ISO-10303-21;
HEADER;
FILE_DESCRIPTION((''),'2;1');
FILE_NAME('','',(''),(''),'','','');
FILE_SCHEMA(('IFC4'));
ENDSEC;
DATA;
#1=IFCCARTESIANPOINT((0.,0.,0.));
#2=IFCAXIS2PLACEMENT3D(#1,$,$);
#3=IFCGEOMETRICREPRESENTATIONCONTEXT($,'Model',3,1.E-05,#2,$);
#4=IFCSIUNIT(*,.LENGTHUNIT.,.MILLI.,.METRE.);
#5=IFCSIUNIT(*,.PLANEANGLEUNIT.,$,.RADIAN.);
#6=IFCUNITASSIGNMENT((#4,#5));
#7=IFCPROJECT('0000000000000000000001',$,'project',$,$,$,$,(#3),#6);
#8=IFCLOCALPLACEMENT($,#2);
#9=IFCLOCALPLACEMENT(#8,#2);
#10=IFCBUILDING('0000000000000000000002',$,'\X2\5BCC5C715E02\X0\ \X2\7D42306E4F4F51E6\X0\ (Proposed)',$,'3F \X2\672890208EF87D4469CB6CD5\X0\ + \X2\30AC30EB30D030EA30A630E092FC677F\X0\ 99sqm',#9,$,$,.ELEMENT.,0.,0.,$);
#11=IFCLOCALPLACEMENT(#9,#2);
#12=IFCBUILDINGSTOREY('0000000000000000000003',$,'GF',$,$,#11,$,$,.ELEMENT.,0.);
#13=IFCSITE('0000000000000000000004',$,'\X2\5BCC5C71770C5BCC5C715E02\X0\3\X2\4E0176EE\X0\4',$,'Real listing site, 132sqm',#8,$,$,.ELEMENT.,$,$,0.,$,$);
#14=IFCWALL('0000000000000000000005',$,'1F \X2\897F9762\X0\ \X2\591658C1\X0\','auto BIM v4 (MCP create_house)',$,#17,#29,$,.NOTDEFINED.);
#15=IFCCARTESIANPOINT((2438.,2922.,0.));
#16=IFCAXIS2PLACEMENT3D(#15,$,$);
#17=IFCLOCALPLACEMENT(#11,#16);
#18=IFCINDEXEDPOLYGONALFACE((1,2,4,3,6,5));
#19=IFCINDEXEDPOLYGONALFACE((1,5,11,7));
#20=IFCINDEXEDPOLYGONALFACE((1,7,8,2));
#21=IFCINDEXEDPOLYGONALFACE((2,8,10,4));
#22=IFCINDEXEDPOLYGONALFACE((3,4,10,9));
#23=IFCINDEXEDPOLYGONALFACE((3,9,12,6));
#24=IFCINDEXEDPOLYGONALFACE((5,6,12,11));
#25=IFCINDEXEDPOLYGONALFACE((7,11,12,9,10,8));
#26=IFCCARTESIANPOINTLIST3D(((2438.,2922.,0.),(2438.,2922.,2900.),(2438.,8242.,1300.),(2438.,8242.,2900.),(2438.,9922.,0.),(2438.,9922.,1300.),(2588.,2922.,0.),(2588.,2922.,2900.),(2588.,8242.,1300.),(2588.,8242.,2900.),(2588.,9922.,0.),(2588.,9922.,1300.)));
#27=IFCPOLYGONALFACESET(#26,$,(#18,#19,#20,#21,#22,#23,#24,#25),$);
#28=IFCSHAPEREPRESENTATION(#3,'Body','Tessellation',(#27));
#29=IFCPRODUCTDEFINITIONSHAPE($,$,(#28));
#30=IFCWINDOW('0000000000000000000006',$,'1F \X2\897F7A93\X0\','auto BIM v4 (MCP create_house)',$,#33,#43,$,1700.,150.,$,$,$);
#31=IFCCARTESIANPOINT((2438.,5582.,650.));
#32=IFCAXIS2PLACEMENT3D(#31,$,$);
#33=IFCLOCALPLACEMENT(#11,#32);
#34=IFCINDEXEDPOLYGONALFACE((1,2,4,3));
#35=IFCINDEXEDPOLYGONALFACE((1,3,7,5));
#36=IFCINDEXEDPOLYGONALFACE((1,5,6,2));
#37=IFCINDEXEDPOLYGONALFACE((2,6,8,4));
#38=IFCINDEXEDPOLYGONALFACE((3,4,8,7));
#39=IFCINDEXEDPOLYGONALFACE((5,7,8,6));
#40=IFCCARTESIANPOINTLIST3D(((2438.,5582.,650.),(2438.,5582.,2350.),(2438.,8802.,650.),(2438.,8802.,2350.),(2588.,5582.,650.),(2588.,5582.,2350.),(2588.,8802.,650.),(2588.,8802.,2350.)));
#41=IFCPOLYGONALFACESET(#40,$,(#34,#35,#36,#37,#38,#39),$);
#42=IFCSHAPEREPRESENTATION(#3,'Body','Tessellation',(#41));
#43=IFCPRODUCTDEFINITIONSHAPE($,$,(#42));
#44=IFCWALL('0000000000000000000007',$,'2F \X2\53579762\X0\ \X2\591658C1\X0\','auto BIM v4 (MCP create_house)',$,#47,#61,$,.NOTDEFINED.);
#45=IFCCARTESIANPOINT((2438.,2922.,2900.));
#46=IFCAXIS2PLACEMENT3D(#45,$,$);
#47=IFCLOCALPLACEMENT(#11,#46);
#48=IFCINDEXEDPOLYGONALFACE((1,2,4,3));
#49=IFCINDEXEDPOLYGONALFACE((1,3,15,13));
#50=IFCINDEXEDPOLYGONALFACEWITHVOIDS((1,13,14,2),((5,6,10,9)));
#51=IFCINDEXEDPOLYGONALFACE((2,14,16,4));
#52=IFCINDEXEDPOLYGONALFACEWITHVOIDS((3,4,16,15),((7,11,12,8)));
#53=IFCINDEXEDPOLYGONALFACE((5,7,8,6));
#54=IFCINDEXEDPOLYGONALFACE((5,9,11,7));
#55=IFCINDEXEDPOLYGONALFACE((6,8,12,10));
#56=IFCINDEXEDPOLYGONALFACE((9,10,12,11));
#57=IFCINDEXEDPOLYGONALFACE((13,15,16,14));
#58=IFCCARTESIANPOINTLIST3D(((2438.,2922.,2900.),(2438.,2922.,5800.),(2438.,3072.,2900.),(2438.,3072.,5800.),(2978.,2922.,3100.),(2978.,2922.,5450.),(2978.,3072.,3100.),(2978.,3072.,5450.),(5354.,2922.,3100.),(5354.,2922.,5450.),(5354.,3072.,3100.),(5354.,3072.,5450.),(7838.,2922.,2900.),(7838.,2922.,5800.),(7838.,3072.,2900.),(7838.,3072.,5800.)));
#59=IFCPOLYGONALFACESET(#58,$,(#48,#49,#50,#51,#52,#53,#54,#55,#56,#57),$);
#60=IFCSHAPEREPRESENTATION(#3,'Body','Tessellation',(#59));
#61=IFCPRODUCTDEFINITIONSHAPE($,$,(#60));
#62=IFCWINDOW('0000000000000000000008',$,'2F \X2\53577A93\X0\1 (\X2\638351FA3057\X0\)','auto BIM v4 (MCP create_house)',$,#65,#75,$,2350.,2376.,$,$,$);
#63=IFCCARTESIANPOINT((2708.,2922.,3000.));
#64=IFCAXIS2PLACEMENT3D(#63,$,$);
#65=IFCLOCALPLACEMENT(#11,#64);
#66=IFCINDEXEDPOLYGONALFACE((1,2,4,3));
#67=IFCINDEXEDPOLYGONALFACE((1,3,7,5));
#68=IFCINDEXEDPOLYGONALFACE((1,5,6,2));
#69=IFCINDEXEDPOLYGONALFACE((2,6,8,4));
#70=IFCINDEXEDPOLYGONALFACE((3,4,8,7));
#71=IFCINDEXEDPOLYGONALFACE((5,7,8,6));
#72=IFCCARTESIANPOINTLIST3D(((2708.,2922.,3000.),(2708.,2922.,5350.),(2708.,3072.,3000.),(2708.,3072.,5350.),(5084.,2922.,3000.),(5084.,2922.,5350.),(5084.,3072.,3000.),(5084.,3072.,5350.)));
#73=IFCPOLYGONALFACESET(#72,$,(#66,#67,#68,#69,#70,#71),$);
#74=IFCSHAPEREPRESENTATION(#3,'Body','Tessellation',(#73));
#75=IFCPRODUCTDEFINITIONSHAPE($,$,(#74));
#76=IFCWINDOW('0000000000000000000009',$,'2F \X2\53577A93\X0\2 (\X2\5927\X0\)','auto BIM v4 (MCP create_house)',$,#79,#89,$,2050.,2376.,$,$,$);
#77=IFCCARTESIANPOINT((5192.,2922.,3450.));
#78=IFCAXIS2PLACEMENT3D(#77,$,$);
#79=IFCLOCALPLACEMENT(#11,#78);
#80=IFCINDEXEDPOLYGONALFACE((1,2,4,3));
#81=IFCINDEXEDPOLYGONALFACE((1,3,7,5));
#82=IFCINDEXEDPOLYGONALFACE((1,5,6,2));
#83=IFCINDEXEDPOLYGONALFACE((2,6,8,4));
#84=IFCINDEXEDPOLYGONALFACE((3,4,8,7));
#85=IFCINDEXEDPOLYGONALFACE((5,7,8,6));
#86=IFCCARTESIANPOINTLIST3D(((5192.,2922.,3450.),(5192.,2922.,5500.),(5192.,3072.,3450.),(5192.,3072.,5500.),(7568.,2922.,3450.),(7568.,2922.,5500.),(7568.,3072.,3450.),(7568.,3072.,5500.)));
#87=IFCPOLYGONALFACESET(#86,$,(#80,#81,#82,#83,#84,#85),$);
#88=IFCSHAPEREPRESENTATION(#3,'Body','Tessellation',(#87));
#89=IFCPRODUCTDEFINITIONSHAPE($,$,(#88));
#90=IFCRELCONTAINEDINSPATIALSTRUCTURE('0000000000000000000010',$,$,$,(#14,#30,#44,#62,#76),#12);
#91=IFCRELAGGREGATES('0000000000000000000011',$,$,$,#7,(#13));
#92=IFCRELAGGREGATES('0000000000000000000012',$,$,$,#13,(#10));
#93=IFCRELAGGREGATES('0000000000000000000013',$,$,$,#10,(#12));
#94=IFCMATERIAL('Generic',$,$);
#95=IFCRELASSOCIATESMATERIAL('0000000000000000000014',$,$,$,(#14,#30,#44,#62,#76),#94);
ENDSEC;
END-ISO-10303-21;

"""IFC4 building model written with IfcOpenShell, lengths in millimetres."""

from ifc_helpers import new_model, si_unit, frame, frame_2d, origin, place, context, project, spatial, rectangle, extrude, material, element, fill, save


model = new_model("IFC4")

# Units and contexts
model_context = context("Model", 3, precision=1e-05, world=origin())
ifc_project = project(units=[si_unit("LENGTHUNIT", "METRE", prefix="MILLI"), si_unit("PLANEANGLEUNIT", "RADIAN")], contexts=[model_context])

# Site, building, storey
site_placement = place(None, origin())
site = spatial("IfcSite", under=ifc_project, at=site_placement, Name="富山県富山市3丁目4", ObjectType="Real listing site, 132sqm", CompositionType="ELEMENT", RefElevation=0.0)
building_placement = place(site_placement, origin())
building = spatial("IfcBuilding", under=site, at=building_placement, Name="富山市 終の住処 (Proposed)", ObjectType="3F 木造軸組構法 + ガルバリウム鋼板 99sqm", CompositionType="ELEMENT", ElevationOfRefHeight=0.0, ElevationOfTerrain=0.0)
storey_placement = place(building_placement, origin())
storey = spatial("IfcBuildingStorey", under=building, at=storey_placement, Name="GF", CompositionType="ELEMENT", Elevation=0.0)

# Shared definitions
ifc_material = material(Name="Generic")

# Wall, opening, window
wall_1_placement = place(storey_placement, frame((2438.0, 2922.0, 0.0)))
wall_1 = element("IfcWall", 1, at=wall_1_placement, inside=storey, material=ifc_material, Name="1F 西面 外壁", Description="auto BIM v4 (MCP create_house)", PredefinedType="NOTDEFINED", context=model_context, shape_type="SweptSolid", body=[
    extrude(rectangle(XDim=150.0, YDim=7000.0, at=frame_2d((75.0, 3500.0))), frame((2438.0, 2922.0, 0.0)), (0.0, 0.0, 1.0), 2900.0),
])
opening_1_placement = place(storey_placement, frame((2438.0, 5582.0, 650.0)))
opening_1 = element("IfcOpeningElement", 2, at=opening_1_placement, cuts=wall_1, PredefinedType="NOTDEFINED", context=model_context, shape_type="SweptSolid", body=[
    extrude(rectangle(XDim=150.0, YDim=3220.0, at=frame_2d((75.0, 1610.0))), frame((2438.0, 5582.0, 650.0)), (0.0, 0.0, 1.0), 1700.0),
])
window_1_placement = place(storey_placement, frame((2438.0, 5582.0, 650.0)))
window_1 = element("IfcWindow", 3, at=window_1_placement, inside=storey, material=ifc_material, Name="1F 西窓", Description="auto BIM v4 (MCP create_house)", OverallHeight=1700.0, OverallWidth=150.0, context=model_context, shape_type="SweptSolid", body=[
    extrude(rectangle(XDim=150.0, YDim=3220.0, at=frame_2d((75.0, 1610.0))), frame((2438.0, 5582.0, 650.0)), (0.0, 0.0, 1.0), 1700.0),
])
fill(opening_1, window_1)

# Wall, openings, windows
wall_2_placement = place(storey_placement, frame((2438.0, 2922.0, 2900.0)))
wall_2 = element("IfcWall", 4, at=wall_2_placement, inside=storey, material=ifc_material, Name="2F 南面 外壁", Description="auto BIM v4 (MCP create_house)", PredefinedType="NOTDEFINED", context=model_context, shape_type="SweptSolid", body=[
    extrude(rectangle(XDim=5400.0, YDim=150.0, at=frame_2d((2700.0, 75.0))), frame((2438.0, 2922.0, 2900.0)), (0.0, 0.0, 1.0), 2900.0),
])
opening_2_placement = place(storey_placement, frame((2708.0, 2922.0, 3000.0)))
opening_2 = element("IfcOpeningElement", 5, at=opening_2_placement, cuts=wall_2, PredefinedType="NOTDEFINED", context=model_context, shape_type="SweptSolid", body=[
    extrude(rectangle(XDim=2376.0, YDim=150.0, at=frame_2d((1188.0, 75.0))), frame((2708.0, 2922.0, 3000.0)), (0.0, 0.0, 1.0), 2350.0),
])
opening_3_placement = place(storey_placement, frame((5192.0, 2922.0, 3450.0)))
opening_3 = element("IfcOpeningElement", 6, at=opening_3_placement, cuts=wall_2, PredefinedType="NOTDEFINED", context=model_context, shape_type="SweptSolid", body=[
    extrude(rectangle(XDim=2376.0, YDim=150.0, at=frame_2d((1188.0, 75.0))), frame((5192.0, 2922.0, 3450.0)), (0.0, 0.0, 1.0), 2050.0),
])
window_2_placement = place(storey_placement, frame((2708.0, 2922.0, 3000.0)))
window_2 = element("IfcWindow", 7, at=window_2_placement, inside=storey, material=ifc_material, Name="2F 南窓1 (掃出し)", Description="auto BIM v4 (MCP create_house)", OverallHeight=2350.0, OverallWidth=2376.0, context=model_context, shape_type="SweptSolid", body=[
    extrude(rectangle(XDim=2376.0, YDim=150.0, at=frame_2d((1188.0, 75.0))), frame((2708.0, 2922.0, 3000.0)), (0.0, 0.0, 1.0), 2350.0),
])
fill(opening_2, window_2)
window_3_placement = place(storey_placement, frame((5192.0, 2922.0, 3450.0)))
window_3 = element("IfcWindow", 8, at=window_3_placement, inside=storey, material=ifc_material, Name="2F 南窓2 (大)", Description="auto BIM v4 (MCP create_house)", OverallHeight=2050.0, OverallWidth=2376.0, context=model_context, shape_type="SweptSolid", body=[
    extrude(rectangle(XDim=2376.0, YDim=150.0, at=frame_2d((1188.0, 75.0))), frame((5192.0, 2922.0, 3450.0)), (0.0, 0.0, 1.0), 2050.0),
])
fill(opening_3, window_3)

save(model, "model.ifc")
